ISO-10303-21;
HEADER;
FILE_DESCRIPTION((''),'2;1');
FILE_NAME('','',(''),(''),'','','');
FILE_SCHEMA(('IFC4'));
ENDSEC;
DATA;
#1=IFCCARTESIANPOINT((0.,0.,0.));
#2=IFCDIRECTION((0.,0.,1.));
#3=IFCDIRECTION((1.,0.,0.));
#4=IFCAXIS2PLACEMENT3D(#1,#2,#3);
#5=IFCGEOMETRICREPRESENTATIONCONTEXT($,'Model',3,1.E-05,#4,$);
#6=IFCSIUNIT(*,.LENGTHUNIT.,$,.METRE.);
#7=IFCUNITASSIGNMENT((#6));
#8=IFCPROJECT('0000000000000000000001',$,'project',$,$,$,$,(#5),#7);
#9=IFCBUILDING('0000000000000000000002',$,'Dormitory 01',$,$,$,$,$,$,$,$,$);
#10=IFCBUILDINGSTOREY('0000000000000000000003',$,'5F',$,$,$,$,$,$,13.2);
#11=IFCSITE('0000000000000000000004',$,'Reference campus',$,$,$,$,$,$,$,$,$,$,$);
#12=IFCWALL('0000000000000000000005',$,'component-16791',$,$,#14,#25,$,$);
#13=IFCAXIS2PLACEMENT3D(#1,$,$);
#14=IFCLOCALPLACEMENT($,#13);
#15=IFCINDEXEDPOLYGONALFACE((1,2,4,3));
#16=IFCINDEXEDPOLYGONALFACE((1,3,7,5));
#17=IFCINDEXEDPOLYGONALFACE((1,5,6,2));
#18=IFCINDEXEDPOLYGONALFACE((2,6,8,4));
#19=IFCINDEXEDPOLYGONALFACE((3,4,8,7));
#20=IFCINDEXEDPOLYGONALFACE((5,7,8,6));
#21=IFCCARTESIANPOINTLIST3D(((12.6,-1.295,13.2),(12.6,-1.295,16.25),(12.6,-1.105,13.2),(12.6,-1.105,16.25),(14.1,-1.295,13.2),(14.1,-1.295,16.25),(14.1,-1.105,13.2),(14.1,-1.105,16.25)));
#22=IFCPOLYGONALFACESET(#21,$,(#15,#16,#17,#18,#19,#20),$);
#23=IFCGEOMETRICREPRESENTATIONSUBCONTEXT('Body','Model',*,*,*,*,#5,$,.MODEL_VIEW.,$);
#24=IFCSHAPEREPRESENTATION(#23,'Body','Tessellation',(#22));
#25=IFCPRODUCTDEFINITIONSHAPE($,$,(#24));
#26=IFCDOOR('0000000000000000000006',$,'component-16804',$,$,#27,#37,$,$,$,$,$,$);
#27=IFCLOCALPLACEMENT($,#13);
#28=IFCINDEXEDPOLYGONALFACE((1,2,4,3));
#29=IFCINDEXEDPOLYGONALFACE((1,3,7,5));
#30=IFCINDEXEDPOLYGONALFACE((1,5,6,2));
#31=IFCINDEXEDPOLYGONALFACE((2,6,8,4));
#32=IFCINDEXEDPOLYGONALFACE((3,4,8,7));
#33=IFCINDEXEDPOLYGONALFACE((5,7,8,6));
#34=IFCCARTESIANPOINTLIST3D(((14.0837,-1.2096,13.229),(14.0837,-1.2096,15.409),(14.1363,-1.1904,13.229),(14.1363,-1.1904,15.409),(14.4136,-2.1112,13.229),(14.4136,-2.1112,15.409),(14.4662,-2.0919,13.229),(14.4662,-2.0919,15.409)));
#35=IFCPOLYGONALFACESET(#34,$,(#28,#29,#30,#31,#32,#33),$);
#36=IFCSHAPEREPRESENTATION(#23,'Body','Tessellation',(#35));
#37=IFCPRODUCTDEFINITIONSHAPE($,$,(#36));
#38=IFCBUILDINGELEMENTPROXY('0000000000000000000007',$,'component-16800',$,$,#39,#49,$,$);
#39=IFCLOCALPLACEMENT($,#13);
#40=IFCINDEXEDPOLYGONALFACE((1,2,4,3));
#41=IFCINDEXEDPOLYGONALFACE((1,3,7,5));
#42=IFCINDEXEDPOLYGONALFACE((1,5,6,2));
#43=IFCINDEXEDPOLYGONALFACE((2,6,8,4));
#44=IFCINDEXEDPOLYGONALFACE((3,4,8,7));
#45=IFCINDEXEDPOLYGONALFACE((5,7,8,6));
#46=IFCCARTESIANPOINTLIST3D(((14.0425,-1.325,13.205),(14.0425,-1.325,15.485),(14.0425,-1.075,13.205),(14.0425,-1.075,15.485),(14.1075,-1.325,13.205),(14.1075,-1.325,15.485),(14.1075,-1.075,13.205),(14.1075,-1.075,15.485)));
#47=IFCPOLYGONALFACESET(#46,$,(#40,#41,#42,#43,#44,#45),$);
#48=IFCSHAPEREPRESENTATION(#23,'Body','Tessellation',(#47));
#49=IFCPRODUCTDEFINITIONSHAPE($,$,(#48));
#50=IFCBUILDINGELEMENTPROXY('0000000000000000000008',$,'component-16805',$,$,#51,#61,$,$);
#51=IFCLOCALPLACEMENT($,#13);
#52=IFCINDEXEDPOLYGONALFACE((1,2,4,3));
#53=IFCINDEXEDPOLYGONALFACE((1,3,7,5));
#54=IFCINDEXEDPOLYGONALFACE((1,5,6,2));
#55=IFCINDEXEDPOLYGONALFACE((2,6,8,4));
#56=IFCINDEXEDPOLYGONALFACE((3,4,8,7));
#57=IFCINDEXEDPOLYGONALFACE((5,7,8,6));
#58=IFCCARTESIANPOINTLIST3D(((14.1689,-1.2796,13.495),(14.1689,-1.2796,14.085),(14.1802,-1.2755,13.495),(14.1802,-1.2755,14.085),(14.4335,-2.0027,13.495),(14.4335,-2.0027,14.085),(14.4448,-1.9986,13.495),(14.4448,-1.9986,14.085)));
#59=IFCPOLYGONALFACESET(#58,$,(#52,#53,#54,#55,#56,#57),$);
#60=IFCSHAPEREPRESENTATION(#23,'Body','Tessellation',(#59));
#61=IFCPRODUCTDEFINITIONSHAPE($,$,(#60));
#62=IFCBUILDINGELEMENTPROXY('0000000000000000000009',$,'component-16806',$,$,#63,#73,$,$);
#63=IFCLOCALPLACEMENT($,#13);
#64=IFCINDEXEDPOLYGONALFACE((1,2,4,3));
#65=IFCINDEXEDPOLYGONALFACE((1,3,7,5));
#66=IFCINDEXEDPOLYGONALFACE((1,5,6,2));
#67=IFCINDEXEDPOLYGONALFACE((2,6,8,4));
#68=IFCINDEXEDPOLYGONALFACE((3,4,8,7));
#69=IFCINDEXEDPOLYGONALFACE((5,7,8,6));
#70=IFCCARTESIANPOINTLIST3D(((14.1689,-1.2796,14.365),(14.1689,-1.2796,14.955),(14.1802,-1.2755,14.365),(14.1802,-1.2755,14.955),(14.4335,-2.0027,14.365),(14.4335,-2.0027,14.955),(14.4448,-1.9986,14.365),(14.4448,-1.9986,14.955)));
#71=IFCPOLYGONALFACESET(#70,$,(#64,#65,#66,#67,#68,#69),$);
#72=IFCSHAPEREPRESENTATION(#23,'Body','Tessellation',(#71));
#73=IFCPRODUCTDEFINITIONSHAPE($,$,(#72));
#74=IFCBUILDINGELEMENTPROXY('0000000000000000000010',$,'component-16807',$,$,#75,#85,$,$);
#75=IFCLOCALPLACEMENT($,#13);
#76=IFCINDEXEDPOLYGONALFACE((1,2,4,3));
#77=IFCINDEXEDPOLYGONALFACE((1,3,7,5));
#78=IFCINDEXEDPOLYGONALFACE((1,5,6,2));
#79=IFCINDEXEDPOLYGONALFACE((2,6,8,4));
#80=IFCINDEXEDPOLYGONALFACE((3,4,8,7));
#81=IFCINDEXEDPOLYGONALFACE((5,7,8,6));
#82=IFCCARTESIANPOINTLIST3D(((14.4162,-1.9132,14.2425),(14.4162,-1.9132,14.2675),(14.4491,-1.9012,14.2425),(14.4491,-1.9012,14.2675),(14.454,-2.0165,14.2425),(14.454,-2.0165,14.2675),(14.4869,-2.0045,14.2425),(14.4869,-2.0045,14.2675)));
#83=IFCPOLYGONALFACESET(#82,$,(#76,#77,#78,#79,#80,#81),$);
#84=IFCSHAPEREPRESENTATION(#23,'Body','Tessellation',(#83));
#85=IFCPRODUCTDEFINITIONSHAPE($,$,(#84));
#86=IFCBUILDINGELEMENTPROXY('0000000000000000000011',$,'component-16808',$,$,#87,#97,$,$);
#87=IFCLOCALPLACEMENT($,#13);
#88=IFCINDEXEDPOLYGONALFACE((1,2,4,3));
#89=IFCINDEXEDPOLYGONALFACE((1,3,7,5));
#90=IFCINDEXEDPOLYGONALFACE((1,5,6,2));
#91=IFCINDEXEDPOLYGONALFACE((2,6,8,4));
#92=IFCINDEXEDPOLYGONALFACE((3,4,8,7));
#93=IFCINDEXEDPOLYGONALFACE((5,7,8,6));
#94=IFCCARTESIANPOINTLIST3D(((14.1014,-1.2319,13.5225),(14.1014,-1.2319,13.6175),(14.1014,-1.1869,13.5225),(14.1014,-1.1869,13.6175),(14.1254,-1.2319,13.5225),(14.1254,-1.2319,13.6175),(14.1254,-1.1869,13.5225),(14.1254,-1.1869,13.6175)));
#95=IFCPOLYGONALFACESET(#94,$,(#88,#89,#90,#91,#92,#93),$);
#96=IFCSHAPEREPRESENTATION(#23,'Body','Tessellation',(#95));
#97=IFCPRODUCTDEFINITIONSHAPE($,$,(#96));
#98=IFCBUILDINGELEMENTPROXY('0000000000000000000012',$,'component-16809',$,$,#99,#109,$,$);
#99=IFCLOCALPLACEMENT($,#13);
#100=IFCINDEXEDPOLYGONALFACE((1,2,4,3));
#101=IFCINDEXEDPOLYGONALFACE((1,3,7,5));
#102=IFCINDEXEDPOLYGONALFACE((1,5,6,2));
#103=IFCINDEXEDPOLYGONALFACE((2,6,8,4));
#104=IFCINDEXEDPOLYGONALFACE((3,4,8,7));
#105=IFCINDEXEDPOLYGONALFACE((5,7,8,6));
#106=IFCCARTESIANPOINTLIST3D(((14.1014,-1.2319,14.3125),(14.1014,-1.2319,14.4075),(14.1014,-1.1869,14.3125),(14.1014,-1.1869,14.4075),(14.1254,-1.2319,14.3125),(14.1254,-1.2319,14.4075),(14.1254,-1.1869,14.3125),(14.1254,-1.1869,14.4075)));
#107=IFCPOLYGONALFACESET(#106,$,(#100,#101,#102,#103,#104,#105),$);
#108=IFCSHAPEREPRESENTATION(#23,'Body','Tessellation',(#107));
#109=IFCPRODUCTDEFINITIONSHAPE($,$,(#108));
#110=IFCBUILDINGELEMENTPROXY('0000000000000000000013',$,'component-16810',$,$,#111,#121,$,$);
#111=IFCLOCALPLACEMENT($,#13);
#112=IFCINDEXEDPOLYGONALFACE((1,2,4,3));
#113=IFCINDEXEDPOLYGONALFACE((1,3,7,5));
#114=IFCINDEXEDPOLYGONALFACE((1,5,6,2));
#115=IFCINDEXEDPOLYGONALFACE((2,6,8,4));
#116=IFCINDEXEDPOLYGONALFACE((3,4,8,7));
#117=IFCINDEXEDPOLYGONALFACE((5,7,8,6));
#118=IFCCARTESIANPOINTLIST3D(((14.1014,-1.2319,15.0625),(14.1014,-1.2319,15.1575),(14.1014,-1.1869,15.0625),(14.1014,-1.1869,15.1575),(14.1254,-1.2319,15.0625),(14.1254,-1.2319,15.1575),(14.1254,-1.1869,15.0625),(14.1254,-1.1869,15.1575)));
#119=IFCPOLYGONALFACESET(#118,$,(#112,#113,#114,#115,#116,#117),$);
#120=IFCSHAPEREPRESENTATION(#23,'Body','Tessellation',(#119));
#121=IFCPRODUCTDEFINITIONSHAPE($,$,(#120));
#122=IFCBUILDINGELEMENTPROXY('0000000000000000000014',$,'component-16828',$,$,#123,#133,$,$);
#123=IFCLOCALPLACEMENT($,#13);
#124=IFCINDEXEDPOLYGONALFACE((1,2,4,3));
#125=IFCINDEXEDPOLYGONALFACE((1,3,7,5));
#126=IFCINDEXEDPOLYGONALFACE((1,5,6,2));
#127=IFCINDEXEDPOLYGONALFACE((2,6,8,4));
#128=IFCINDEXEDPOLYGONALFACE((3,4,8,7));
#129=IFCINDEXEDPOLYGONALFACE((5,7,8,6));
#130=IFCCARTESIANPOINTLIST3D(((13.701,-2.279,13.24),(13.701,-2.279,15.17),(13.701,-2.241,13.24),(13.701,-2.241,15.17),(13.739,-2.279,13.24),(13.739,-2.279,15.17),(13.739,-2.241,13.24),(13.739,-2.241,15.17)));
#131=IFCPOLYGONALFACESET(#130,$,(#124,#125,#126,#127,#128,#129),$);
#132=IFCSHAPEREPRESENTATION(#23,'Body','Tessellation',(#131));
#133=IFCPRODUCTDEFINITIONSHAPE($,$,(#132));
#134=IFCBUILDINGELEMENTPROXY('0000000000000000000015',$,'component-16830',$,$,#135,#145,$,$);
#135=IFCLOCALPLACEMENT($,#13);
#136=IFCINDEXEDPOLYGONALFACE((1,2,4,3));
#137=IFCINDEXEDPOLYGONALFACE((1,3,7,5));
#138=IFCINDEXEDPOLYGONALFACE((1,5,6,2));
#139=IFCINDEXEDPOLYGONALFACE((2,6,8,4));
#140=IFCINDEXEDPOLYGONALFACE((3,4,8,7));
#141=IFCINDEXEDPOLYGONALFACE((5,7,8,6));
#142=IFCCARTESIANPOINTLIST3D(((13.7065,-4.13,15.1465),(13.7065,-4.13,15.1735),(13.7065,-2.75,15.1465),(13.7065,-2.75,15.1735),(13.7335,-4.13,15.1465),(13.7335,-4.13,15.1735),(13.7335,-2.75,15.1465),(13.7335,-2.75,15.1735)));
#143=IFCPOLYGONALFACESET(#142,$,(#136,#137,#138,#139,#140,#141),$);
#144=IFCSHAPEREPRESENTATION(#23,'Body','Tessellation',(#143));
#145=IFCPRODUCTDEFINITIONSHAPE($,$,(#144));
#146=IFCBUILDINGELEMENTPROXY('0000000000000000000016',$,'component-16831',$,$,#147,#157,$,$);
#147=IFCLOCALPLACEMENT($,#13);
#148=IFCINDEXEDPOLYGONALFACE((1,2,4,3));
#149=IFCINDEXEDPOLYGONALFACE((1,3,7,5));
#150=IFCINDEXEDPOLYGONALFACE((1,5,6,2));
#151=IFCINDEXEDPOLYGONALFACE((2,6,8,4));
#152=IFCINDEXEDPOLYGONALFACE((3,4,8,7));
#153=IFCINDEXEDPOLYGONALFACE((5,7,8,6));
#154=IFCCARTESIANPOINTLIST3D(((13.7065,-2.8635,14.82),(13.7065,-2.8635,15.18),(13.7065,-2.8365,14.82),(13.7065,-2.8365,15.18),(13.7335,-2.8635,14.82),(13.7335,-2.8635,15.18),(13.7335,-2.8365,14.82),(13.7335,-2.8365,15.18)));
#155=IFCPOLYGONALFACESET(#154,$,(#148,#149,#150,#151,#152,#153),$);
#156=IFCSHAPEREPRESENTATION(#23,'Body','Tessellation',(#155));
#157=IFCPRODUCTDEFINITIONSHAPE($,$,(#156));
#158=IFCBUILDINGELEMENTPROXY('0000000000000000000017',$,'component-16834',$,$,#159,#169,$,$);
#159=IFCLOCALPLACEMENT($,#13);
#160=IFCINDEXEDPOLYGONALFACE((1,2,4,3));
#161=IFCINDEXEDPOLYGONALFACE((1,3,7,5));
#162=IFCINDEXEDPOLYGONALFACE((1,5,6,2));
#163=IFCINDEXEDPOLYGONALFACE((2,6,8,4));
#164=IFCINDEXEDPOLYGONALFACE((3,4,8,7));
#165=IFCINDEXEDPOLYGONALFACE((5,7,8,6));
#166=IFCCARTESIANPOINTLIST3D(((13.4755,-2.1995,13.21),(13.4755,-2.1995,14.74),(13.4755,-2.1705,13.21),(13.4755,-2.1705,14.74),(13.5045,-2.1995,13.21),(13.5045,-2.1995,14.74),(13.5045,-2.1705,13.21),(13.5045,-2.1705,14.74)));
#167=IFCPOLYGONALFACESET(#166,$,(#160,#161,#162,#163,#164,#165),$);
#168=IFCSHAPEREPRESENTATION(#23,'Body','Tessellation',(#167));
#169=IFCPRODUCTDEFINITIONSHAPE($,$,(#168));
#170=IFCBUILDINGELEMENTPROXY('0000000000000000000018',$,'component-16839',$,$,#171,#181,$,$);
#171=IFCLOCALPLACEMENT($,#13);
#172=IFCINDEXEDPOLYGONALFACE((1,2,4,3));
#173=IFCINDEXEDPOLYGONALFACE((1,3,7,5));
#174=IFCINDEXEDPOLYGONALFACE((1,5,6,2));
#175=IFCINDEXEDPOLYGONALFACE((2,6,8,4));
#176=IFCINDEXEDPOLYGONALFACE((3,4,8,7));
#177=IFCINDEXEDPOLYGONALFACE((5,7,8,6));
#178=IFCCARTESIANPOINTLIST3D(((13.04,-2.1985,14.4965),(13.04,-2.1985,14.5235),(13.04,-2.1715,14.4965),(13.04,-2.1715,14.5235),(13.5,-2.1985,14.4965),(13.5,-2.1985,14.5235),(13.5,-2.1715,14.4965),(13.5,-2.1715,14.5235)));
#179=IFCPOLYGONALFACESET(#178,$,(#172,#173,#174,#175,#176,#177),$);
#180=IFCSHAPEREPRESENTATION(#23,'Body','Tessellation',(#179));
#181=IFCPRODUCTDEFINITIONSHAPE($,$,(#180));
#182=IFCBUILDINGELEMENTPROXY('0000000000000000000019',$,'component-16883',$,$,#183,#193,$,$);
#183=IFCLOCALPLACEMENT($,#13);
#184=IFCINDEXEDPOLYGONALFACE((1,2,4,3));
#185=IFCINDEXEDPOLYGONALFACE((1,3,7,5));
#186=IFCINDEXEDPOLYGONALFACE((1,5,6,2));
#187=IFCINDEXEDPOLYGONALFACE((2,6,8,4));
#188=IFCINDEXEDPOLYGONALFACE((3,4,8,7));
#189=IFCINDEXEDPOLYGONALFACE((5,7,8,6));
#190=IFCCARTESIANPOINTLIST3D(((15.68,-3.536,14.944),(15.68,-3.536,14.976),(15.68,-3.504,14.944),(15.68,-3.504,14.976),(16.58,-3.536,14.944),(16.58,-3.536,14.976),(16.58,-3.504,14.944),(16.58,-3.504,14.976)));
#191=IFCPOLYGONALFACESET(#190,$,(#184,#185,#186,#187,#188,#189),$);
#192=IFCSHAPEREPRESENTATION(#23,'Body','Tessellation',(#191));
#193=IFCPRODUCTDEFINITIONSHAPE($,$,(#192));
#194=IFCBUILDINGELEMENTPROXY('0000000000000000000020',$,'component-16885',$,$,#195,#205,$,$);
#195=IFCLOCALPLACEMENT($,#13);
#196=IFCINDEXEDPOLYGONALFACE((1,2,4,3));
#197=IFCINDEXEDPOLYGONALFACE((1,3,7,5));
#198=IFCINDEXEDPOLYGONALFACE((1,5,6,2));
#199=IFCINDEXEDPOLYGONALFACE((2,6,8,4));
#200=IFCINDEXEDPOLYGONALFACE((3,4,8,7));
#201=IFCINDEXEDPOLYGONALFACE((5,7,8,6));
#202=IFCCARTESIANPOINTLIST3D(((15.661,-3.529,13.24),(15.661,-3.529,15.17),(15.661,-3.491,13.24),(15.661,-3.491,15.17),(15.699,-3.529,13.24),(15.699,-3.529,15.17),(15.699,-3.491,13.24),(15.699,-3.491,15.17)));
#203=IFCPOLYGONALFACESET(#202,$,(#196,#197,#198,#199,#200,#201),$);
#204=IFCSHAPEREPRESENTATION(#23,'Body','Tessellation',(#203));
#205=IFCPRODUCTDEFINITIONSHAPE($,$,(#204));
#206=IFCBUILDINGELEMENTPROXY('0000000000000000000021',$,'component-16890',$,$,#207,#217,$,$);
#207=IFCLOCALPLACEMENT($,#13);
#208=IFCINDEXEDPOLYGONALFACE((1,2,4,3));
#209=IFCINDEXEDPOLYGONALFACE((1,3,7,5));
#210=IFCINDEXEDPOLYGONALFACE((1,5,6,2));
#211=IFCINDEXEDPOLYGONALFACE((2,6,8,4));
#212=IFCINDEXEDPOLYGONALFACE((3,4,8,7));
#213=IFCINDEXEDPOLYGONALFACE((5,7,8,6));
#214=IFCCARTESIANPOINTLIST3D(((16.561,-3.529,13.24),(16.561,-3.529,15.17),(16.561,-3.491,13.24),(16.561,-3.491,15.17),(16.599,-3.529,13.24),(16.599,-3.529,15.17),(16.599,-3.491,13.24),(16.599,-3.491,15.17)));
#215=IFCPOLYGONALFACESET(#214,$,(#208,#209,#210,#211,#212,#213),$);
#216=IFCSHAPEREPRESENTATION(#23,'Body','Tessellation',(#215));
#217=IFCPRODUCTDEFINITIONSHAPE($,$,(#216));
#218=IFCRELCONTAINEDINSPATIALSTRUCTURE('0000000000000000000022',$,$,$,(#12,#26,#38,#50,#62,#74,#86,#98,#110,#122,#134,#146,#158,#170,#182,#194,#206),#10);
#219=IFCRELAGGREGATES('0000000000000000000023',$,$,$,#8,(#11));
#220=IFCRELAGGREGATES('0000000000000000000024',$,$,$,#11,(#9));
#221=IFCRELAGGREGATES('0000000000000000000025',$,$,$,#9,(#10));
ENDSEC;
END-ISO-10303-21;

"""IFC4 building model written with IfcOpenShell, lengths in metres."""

from ifc_helpers import new_model, si_unit, frame, origin, origin_with_axes, origin_2d, place, context, subcontext, project, spatial, rectangle, extrude, element, save


model = new_model("IFC4")

# Units and contexts
model_context = context("Model", 3, precision=1e-05, world=origin_with_axes())
body_context = subcontext(model_context, "Body", "Model", "MODEL_VIEW")
ifc_project = project(units=[si_unit("LENGTHUNIT", "METRE")], contexts=[model_context])

# Site, building, storey
site = spatial("IfcSite", under=ifc_project, Name="Reference campus")
building = spatial("IfcBuilding", under=site, Name="Dormitory 01")
storey = spatial("IfcBuildingStorey", under=building, Name="5F", Elevation=13.2)

# Wall
wall_placement = place(None, frame((13.35, -1.2, 13.2), z_axis=(0.0, 0.0, 1.0), x_axis=(1.0, 0.0, 0.0)))
element("IfcWall", 1, at=wall_placement, inside=storey, Name="component-16791", context=body_context, shape_type="SweptSolid", body=[
    extrude(rectangle(XDim=1.5, YDim=0.19, at=origin_2d()), origin(), (0.0, 0.0, 1.0), 3.05),
])

# Door
door_placement = place(None, frame((14.2749, -1.6508, 13.229), z_axis=(0.0, 0.0, 1.0), x_axis=(0.343646, -0.939099, 0.0)))
element("IfcDoor", 2, at=door_placement, inside=storey, Name="component-16804", context=body_context, shape_type="SweptSolid", body=[
    extrude(rectangle(XDim=0.96, YDim=0.056, at=origin_2d()), origin(), (0.0, 0.0, 1.0), 2.18),
])

# Building element proxies
proxy_1_placement = place(None, frame((14.075, -1.2, 13.205), z_axis=(0.0, 0.0, 1.0), x_axis=(1.0, 0.0, 0.0)))
element("IfcBuildingElementProxy", 3, at=proxy_1_placement, inside=storey, Name="component-16800", context=body_context, shape_type="SweptSolid", body=[
    extrude(rectangle(XDim=0.065, YDim=0.25, at=origin_2d()), origin(), (0.0, 0.0, 1.0), 2.28),
])
for number, where, z_axis, x_axis, name in (
    (4, (14.3069, -1.6391, 13.495), (0.0, 0.0, 1.0), (0.343646, -0.939099, 0.0), "component-16805"),
    (5, (14.3069, -1.6391, 14.365), (0.0, 0.0, 1.0), (0.343646, -0.939099, 0.0), "component-16806"),
):
    element("IfcBuildingElementProxy", number, at=place(None, frame(where, z_axis=z_axis, x_axis=x_axis)), inside=storey, Name=name, context=body_context, shape_type="SweptSolid", body=[
        extrude(rectangle(XDim=0.77, YDim=0.012, at=origin_2d()), origin(), (0.0, 0.0, 1.0), 0.59),
    ])
proxy_2_placement = place(None, frame((14.4516, -1.9588, 14.2425), z_axis=(0.0, 0.0, 1.0), x_axis=(0.343646, -0.939099, 0.0)))
element("IfcBuildingElementProxy", 6, at=proxy_2_placement, inside=storey, Name="component-16807", context=body_context, shape_type="SweptSolid", body=[
    extrude(rectangle(XDim=0.11, YDim=0.035, at=origin_2d()), origin(), (0.0, 0.0, 1.0), 0.025),
])
for number, where, z_axis, x_axis, name in (
    (7, (14.1134, -1.2094, 13.5225), (0.0, 0.0, 1.0), (1.0, 0.0, 0.0), "component-16808"),
    (8, (14.1134, -1.2094, 14.3125), (0.0, 0.0, 1.0), (1.0, 0.0, 0.0), "component-16809"),
    (9, (14.1134, -1.2094, 15.0625), (0.0, 0.0, 1.0), (1.0, 0.0, 0.0), "component-16810"),
):
    element("IfcBuildingElementProxy", number, at=place(None, frame(where, z_axis=z_axis, x_axis=x_axis)), inside=storey, Name=name, context=body_context, shape_type="SweptSolid", body=[
        extrude(rectangle(XDim=0.024, YDim=0.045, at=origin_2d()), origin(), (0.0, 0.0, 1.0), 0.095),
    ])
proxy_3_placement = place(None, frame((13.72, -2.26, 13.24), z_axis=(0.0, 0.0, 1.0), x_axis=(1.0, 0.0, 0.0)))
element("IfcBuildingElementProxy", 10, at=proxy_3_placement, inside=storey, Name="component-16828", context=body_context, shape_type="SweptSolid", body=[
    extrude(rectangle(XDim=0.038, YDim=0.038, at=origin_2d()), origin(), (0.0, 0.0, 1.0), 1.93),
])
proxy_4_placement = place(None, frame((13.72, -3.44, 15.1465), z_axis=(0.0, 0.0, 1.0), x_axis=(1.0, 0.0, 0.0)))
element("IfcBuildingElementProxy", 11, at=proxy_4_placement, inside=storey, Name="component-16830", context=body_context, shape_type="SweptSolid", body=[
    extrude(rectangle(XDim=0.027, YDim=1.38, at=origin_2d()), origin(), (0.0, 0.0, 1.0), 0.027),
])
proxy_5_placement = place(None, frame((13.72, -2.85, 14.82), z_axis=(0.0, 0.0, 1.0), x_axis=(1.0, 0.0, 0.0)))
element("IfcBuildingElementProxy", 12, at=proxy_5_placement, inside=storey, Name="component-16831", context=body_context, shape_type="SweptSolid", body=[
    extrude(rectangle(XDim=0.027, YDim=0.027, at=origin_2d()), origin(), (0.0, 0.0, 1.0), 0.36),
])
proxy_6_placement = place(None, frame((13.49, -2.185, 13.21), z_axis=(0.0, 0.0, 1.0), x_axis=(1.0, 0.0, 0.0)))
element("IfcBuildingElementProxy", 13, at=proxy_6_placement, inside=storey, Name="component-16834", context=body_context, shape_type="SweptSolid", body=[
    extrude(rectangle(XDim=0.029, YDim=0.029, at=origin_2d()), origin(), (0.0, 0.0, 1.0), 1.53),
])
proxy_7_placement = place(None, frame((13.27, -2.185, 14.4965), z_axis=(0.0, 0.0, 1.0), x_axis=(1.0, 0.0, 0.0)))
element("IfcBuildingElementProxy", 14, at=proxy_7_placement, inside=storey, Name="component-16839", context=body_context, shape_type="SweptSolid", body=[
    extrude(rectangle(XDim=0.46, YDim=0.027, at=origin_2d()), origin(), (0.0, 0.0, 1.0), 0.027),
])
proxy_8_placement = place(None, frame((16.13, -3.52, 14.944), z_axis=(0.0, 0.0, 1.0), x_axis=(1.0, 0.0, 0.0)))
element("IfcBuildingElementProxy", 15, at=proxy_8_placement, inside=storey, Name="component-16883", context=body_context, shape_type="SweptSolid", body=[
    extrude(rectangle(XDim=0.9, YDim=0.032, at=origin_2d()), origin(), (0.0, 0.0, 1.0), 0.032),
])
for number, where, z_axis, x_axis, name in (
    (16, (15.68, -3.51, 13.24), (0.0, 0.0, 1.0), (1.0, 0.0, 0.0), "component-16885"),
    (17, (16.58, -3.51, 13.24), (0.0, 0.0, 1.0), (1.0, 0.0, 0.0), "component-16890"),
):
    element("IfcBuildingElementProxy", number, at=place(None, frame(where, z_axis=z_axis, x_axis=x_axis)), inside=storey, Name=name, context=body_context, shape_type="SweptSolid", body=[
        extrude(rectangle(XDim=0.038, YDim=0.038, at=origin_2d()), origin(), (0.0, 0.0, 1.0), 1.93),
    ])

save(model, "model.ifc")
